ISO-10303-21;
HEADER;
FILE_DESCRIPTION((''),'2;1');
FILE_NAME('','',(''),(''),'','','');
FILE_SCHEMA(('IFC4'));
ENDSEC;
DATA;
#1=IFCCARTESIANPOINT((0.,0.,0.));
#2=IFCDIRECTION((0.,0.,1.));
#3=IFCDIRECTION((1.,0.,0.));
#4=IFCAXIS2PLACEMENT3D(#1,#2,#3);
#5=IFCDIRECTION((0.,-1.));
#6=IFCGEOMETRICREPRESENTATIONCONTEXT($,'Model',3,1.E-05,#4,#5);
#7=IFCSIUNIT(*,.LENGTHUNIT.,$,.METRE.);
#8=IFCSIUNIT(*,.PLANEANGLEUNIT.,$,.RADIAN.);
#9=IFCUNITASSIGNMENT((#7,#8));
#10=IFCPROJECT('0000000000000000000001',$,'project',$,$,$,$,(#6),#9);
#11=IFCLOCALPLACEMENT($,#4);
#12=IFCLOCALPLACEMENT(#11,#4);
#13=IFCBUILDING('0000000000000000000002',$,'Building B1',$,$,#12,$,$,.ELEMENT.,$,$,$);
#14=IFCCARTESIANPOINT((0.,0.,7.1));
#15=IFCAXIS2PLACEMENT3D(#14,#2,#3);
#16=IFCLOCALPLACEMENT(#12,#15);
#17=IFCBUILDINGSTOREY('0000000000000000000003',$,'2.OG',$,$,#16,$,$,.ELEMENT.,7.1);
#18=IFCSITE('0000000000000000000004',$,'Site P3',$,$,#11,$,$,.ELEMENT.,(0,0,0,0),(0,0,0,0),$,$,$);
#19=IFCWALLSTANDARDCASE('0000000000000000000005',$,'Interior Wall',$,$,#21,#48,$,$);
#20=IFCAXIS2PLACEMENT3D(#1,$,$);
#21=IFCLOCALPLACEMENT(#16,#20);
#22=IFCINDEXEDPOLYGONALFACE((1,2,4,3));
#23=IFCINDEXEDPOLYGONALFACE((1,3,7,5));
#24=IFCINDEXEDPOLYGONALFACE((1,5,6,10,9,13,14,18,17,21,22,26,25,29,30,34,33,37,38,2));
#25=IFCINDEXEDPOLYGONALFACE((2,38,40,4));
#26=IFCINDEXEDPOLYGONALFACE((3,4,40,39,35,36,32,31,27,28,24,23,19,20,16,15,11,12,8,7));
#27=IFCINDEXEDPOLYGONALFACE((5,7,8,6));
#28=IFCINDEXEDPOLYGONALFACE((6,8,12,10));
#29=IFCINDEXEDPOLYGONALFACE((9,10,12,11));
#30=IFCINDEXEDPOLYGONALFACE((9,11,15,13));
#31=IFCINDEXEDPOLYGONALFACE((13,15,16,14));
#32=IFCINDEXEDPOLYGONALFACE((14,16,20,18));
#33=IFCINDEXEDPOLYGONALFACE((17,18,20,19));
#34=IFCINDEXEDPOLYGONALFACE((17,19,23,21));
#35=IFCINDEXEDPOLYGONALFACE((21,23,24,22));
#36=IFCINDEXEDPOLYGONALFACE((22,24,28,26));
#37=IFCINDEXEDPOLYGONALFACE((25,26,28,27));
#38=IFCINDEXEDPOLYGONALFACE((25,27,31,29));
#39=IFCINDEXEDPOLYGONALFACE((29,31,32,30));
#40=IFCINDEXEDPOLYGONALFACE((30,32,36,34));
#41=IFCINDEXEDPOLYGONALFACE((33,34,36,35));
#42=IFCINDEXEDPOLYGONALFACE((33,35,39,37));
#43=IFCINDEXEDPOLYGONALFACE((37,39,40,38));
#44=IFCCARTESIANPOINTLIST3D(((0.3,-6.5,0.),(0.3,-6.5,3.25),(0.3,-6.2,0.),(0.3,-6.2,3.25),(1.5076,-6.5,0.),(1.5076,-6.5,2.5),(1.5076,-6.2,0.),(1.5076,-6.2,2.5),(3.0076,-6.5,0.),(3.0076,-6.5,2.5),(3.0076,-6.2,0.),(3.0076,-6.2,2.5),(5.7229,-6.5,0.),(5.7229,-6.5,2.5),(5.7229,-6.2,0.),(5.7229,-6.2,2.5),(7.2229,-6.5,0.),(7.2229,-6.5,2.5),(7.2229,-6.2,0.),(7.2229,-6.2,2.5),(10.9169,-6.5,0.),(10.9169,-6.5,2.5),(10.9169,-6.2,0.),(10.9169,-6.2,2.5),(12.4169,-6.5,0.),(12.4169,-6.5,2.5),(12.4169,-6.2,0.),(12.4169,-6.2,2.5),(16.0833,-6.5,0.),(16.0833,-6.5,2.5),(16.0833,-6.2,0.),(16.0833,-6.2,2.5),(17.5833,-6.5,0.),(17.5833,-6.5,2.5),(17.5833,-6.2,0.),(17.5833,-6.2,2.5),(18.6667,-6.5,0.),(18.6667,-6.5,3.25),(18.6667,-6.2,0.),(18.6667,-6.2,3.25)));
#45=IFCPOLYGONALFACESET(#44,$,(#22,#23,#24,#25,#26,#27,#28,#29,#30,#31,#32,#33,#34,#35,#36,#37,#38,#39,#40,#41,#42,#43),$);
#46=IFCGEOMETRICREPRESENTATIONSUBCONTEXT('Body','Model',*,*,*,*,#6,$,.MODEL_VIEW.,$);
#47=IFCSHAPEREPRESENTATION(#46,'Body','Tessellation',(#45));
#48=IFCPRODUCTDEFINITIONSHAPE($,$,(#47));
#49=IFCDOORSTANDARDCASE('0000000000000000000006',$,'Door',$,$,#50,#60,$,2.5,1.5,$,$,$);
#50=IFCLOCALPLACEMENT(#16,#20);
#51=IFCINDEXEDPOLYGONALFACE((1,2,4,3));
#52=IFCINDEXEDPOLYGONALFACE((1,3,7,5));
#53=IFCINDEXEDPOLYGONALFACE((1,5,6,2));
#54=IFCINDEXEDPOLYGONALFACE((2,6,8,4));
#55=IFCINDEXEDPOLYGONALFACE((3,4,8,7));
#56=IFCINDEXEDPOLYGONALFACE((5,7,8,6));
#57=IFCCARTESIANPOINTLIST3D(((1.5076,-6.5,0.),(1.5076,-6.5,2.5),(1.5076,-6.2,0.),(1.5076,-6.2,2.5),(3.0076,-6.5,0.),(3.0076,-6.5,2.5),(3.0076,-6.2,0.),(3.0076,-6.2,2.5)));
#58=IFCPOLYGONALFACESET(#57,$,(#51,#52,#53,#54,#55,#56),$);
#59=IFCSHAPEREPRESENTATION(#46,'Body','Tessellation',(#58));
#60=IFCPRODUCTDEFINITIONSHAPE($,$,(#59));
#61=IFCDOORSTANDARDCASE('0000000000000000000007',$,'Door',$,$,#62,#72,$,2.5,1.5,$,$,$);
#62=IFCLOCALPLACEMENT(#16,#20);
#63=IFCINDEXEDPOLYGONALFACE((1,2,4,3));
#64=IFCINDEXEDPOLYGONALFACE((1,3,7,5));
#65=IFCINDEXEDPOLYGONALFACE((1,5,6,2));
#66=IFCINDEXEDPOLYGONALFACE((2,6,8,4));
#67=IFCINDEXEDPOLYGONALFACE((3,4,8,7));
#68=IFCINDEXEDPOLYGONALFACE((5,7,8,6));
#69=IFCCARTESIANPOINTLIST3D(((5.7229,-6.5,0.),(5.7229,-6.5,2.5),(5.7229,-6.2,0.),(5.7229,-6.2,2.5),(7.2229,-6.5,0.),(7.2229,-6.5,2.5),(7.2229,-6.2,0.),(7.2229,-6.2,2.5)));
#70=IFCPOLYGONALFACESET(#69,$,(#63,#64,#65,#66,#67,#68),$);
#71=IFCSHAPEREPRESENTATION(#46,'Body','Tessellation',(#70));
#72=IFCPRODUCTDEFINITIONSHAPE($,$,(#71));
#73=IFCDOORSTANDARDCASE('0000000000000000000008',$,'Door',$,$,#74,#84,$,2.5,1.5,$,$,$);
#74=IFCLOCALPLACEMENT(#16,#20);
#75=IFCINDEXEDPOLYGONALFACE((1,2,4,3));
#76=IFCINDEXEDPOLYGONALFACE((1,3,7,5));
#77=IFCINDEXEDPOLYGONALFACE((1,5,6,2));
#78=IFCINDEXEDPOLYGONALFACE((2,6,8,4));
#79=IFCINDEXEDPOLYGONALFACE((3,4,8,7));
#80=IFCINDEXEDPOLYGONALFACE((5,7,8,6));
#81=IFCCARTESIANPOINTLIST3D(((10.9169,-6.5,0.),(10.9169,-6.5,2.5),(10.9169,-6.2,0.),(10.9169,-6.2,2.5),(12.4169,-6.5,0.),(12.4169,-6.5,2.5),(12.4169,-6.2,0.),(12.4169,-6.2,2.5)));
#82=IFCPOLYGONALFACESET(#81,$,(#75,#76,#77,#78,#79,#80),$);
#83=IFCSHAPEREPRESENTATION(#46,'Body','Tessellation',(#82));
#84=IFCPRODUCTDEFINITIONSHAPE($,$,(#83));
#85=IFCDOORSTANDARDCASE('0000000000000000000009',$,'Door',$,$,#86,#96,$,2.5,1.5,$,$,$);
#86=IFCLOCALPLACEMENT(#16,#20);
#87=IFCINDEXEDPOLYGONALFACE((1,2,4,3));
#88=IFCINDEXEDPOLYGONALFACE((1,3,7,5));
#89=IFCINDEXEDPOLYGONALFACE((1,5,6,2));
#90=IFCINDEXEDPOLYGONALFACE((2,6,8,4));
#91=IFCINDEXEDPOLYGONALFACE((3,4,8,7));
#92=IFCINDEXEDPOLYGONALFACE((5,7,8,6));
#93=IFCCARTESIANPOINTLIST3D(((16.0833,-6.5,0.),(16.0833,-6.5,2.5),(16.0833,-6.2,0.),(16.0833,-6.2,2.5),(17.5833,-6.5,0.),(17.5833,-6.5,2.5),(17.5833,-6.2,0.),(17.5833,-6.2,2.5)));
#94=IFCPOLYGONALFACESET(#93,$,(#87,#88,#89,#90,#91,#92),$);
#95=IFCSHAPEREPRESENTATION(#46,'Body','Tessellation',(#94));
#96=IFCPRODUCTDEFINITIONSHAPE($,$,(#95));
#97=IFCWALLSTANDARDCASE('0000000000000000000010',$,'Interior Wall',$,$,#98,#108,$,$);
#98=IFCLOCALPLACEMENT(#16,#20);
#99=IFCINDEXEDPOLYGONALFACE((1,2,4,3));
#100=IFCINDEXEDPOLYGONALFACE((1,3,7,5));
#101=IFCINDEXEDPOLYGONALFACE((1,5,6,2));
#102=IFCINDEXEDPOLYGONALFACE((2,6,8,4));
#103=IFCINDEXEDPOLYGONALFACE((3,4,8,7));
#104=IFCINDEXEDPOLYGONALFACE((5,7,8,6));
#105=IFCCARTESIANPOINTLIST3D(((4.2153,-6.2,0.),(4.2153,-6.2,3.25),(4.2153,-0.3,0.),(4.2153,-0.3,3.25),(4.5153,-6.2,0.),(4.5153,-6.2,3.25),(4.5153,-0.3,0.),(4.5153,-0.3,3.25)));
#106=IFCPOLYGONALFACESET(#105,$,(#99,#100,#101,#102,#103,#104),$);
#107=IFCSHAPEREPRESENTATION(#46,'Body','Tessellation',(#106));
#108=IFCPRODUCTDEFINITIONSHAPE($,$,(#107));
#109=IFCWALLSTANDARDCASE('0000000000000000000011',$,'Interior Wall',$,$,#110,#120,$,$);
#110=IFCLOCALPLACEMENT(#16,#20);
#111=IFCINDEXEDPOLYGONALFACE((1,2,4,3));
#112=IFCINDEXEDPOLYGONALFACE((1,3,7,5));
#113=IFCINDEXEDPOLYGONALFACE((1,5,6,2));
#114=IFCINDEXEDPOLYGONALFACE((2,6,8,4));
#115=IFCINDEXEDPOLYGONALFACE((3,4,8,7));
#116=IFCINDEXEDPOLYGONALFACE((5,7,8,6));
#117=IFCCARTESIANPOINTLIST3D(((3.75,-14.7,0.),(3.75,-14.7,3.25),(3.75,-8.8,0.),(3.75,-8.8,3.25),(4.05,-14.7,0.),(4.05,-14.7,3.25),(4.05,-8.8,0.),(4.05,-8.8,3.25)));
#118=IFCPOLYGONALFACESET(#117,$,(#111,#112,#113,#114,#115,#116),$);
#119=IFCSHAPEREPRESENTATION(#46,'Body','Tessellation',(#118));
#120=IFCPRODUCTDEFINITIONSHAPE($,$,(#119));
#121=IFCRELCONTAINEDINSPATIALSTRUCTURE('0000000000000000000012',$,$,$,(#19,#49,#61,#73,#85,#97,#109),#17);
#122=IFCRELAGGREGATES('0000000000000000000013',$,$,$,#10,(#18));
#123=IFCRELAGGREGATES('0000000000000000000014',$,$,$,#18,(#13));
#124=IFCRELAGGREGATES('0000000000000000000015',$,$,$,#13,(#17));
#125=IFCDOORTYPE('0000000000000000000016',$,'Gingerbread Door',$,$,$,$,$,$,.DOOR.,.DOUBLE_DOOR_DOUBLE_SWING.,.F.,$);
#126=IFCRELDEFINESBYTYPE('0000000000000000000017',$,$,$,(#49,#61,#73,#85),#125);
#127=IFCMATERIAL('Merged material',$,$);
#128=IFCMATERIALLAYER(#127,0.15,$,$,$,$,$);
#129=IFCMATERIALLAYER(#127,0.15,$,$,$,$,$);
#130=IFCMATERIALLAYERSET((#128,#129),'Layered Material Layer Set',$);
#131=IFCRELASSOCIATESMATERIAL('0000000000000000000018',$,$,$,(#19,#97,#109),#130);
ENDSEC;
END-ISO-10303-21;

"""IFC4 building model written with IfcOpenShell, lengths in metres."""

from ifc_helpers import new_model, si_unit, direction, frame, origin_with_axes, place, context, subcontext, project, spatial, polyline, outline, extrude, source, transform, mapped, material, layer, layer_set, layer_usage, type_object, element, fill, save


model = new_model("IFC4")

# Units and contexts
model_context = context("Model", 3, precision=1e-05, world=origin_with_axes(), true_north=direction((0.0, -1.0)))
body_context = subcontext(model_context, "Body", "Model", "MODEL_VIEW")
ifc_project = project(units=[si_unit("LENGTHUNIT", "METRE"), si_unit("PLANEANGLEUNIT", "RADIAN")], contexts=[model_context])

# Site, building, storey
site_placement = place(None, origin_with_axes())
site = spatial("IfcSite", under=ifc_project, at=site_placement, Name="Site P3", CompositionType="ELEMENT", RefLatitude=(0, 0, 0, 0), RefLongitude=(0, 0, 0, 0))
building_placement = place(site_placement, origin_with_axes())
building = spatial("IfcBuilding", under=site, at=building_placement, Name="Building B1", CompositionType="ELEMENT")
storey_placement = place(building_placement, frame((0.0, 0.0, 7.1), z_axis=(0.0, 0.0, 1.0), x_axis=(1.0, 0.0, 0.0)))
storey = spatial("IfcBuildingStorey", under=building, at=storey_placement, Name="2.OG", CompositionType="ELEMENT", Elevation=7.1)

# Shared definitions
ifc_material = material(Name="Merged material")

# Wall, openings, doors
ifc_layer_1 = layer(ifc_material, 0.15)
ifc_layer_2 = layer(ifc_material, 0.15)
ifc_layer_set_1 = layer_set([ifc_layer_1, ifc_layer_2], Name="Layered Material Layer Set")
ifc_layer_usage_1 = layer_usage(ifc_layer_set_1, "AXIS2", "POSITIVE", -0.15)
door_type = type_object("IfcDoorType", Name="Gingerbread Door", OperationType="DOUBLE_DOOR_DOUBLE_SWING", ParameterTakesPrecedence=False, PredefinedType="DOOR")
shared_shape_1 = source(origin_with_axes(), body_context, "Body", "SweptSolid", [
    extrude(outline(polyline([(0.0, 0.0), (0.0, 1.5), (2.5, 1.5), (2.5, 0.0), (0.0, 0.0)])), frame((0.0, -0.15, 0.0), z_axis=(0.0, 1.0, 0.0), x_axis=(0.0, 0.0, 1.0)), (0.0, 0.0, 1.0), 0.3),
])
wall_1_placement = place(storey_placement, frame((0.3, -6.35, 0.0), z_axis=(0.0, 0.0, 1.0), x_axis=(1.0, 0.0, 0.0)))
wall_1 = element("IfcWallStandardCase", 1, at=wall_1_placement, inside=storey, material=ifc_layer_usage_1, Name="Interior Wall", context=body_context, shape_type="SweptSolid", body=[
    extrude(outline(polyline([(0.0, 0.15), (18.3667, 0.15), (18.3667, -0.15), (0.0, -0.15), (0.0, 0.15)])), origin_with_axes(), (0.0, 0.0, 1.0), 3.25),
])
opening_1_placement = place(wall_1_placement, frame((1.2076, 0.0, 0.0), z_axis=(0.0, 0.0, 1.0), x_axis=(1.0, 0.0, 0.0)))
opening_1 = element("IfcOpeningStandardCase", 2, at=opening_1_placement, cuts=wall_1, context=body_context, shape_type="SweptSolid", body=[
    extrude(outline(polyline([(0.0, 0.0), (0.0, 1.5), (2.5, 1.5), (2.5, 0.0), (0.0, 0.0)])), frame((0.0, -0.15, 0.0), z_axis=(0.0, 1.0, 0.0), x_axis=(0.0, 0.0, 1.0)), (0.0, 0.0, 1.0), 0.3),
])
opening_2_placement = place(wall_1_placement, frame((5.4229, 0.0, 0.0), z_axis=(0.0, 0.0, 1.0), x_axis=(1.0, 0.0, 0.0)))
opening_2 = element("IfcOpeningStandardCase", 3, at=opening_2_placement, cuts=wall_1, context=body_context, shape_type="SweptSolid", body=[
    extrude(outline(polyline([(0.0, 0.0), (0.0, 1.5), (2.5, 1.5), (2.5, 0.0), (0.0, 0.0)])), frame((0.0, -0.15, 0.0), z_axis=(0.0, 1.0, 0.0), x_axis=(0.0, 0.0, 1.0)), (0.0, 0.0, 1.0), 0.3),
])
opening_3_placement = place(wall_1_placement, frame((10.6169, 0.0, 0.0), z_axis=(0.0, 0.0, 1.0), x_axis=(1.0, 0.0, 0.0)))
opening_3 = element("IfcOpeningStandardCase", 4, at=opening_3_placement, cuts=wall_1, context=body_context, shape_type="SweptSolid", body=[
    extrude(outline(polyline([(0.0, 0.0), (0.0, 1.5), (2.5, 1.5), (2.5, 0.0), (0.0, 0.0)])), frame((0.0, -0.15, 0.0), z_axis=(0.0, 1.0, 0.0), x_axis=(0.0, 0.0, 1.0)), (0.0, 0.0, 1.0), 0.3),
])
opening_4_placement = place(wall_1_placement, frame((15.7833, 0.0, 0.0), z_axis=(0.0, 0.0, 1.0), x_axis=(1.0, 0.0, 0.0)))
opening_4 = element("IfcOpeningStandardCase", 5, at=opening_4_placement, cuts=wall_1, context=body_context, shape_type="SweptSolid", body=[
    extrude(outline(polyline([(0.0, 0.0), (0.0, 1.5), (2.5, 1.5), (2.5, 0.0), (0.0, 0.0)])), frame((0.0, -0.15, 0.0), z_axis=(0.0, 1.0, 0.0), x_axis=(0.0, 0.0, 1.0)), (0.0, 0.0, 1.0), 0.3),
])
door_1_placement = place(opening_1_placement, origin_with_axes())
door_1 = element("IfcDoorStandardCase", 6, at=door_1_placement, inside=storey, type_object=door_type, Name="Door", OverallHeight=2.5, OverallWidth=1.5, context=body_context, shape_type="MappedRepresentation", body=[
    mapped(shared_shape_1, transform((0.0, 0.0, 0.0))),
])
fill(opening_1, door_1)
door_2_placement = place(opening_2_placement, origin_with_axes())
door_2 = element("IfcDoorStandardCase", 7, at=door_2_placement, inside=storey, type_object=door_type, Name="Door", OverallHeight=2.5, OverallWidth=1.5, context=body_context, shape_type="MappedRepresentation", body=[
    mapped(shared_shape_1, transform((0.0, 0.0, 0.0))),
])
fill(opening_2, door_2)
door_3_placement = place(opening_3_placement, origin_with_axes())
door_3 = element("IfcDoorStandardCase", 8, at=door_3_placement, inside=storey, type_object=door_type, Name="Door", OverallHeight=2.5, OverallWidth=1.5, context=body_context, shape_type="MappedRepresentation", body=[
    mapped(shared_shape_1, transform((0.0, 0.0, 0.0))),
])
fill(opening_3, door_3)
door_4_placement = place(opening_4_placement, origin_with_axes())
door_4 = element("IfcDoorStandardCase", 9, at=door_4_placement, inside=storey, type_object=door_type, Name="Door", OverallHeight=2.5, OverallWidth=1.5, context=body_context, shape_type="MappedRepresentation", body=[
    mapped(shared_shape_1, transform((0.0, 0.0, 0.0))),
])
fill(opening_4, door_4)

# Walls
for number, where, z_axis, x_axis, name in (
    (10, (4.3653, -0.3, 0.0), (0.0, 0.0, 1.0), (0.0, -1.0, 0.0), "Interior Wall"),
    (11, (3.9, -8.8, 0.0), (0.0, 0.0, 1.0), (0.0, -1.0, 0.0), "Interior Wall"),
):
    element("IfcWallStandardCase", number, at=place(storey_placement, frame(where, z_axis=z_axis, x_axis=x_axis)), inside=storey, material=ifc_layer_usage_1, Name=name, context=body_context, shape_type="SweptSolid", body=[
        extrude(outline(polyline([(0.0, 0.15), (5.9, 0.15), (5.9, -0.15), (0.0, -0.15), (0.0, 0.15)])), origin_with_axes(), (0.0, 0.0, 1.0), 3.25),
    ])

save(model, "model.ifc")
